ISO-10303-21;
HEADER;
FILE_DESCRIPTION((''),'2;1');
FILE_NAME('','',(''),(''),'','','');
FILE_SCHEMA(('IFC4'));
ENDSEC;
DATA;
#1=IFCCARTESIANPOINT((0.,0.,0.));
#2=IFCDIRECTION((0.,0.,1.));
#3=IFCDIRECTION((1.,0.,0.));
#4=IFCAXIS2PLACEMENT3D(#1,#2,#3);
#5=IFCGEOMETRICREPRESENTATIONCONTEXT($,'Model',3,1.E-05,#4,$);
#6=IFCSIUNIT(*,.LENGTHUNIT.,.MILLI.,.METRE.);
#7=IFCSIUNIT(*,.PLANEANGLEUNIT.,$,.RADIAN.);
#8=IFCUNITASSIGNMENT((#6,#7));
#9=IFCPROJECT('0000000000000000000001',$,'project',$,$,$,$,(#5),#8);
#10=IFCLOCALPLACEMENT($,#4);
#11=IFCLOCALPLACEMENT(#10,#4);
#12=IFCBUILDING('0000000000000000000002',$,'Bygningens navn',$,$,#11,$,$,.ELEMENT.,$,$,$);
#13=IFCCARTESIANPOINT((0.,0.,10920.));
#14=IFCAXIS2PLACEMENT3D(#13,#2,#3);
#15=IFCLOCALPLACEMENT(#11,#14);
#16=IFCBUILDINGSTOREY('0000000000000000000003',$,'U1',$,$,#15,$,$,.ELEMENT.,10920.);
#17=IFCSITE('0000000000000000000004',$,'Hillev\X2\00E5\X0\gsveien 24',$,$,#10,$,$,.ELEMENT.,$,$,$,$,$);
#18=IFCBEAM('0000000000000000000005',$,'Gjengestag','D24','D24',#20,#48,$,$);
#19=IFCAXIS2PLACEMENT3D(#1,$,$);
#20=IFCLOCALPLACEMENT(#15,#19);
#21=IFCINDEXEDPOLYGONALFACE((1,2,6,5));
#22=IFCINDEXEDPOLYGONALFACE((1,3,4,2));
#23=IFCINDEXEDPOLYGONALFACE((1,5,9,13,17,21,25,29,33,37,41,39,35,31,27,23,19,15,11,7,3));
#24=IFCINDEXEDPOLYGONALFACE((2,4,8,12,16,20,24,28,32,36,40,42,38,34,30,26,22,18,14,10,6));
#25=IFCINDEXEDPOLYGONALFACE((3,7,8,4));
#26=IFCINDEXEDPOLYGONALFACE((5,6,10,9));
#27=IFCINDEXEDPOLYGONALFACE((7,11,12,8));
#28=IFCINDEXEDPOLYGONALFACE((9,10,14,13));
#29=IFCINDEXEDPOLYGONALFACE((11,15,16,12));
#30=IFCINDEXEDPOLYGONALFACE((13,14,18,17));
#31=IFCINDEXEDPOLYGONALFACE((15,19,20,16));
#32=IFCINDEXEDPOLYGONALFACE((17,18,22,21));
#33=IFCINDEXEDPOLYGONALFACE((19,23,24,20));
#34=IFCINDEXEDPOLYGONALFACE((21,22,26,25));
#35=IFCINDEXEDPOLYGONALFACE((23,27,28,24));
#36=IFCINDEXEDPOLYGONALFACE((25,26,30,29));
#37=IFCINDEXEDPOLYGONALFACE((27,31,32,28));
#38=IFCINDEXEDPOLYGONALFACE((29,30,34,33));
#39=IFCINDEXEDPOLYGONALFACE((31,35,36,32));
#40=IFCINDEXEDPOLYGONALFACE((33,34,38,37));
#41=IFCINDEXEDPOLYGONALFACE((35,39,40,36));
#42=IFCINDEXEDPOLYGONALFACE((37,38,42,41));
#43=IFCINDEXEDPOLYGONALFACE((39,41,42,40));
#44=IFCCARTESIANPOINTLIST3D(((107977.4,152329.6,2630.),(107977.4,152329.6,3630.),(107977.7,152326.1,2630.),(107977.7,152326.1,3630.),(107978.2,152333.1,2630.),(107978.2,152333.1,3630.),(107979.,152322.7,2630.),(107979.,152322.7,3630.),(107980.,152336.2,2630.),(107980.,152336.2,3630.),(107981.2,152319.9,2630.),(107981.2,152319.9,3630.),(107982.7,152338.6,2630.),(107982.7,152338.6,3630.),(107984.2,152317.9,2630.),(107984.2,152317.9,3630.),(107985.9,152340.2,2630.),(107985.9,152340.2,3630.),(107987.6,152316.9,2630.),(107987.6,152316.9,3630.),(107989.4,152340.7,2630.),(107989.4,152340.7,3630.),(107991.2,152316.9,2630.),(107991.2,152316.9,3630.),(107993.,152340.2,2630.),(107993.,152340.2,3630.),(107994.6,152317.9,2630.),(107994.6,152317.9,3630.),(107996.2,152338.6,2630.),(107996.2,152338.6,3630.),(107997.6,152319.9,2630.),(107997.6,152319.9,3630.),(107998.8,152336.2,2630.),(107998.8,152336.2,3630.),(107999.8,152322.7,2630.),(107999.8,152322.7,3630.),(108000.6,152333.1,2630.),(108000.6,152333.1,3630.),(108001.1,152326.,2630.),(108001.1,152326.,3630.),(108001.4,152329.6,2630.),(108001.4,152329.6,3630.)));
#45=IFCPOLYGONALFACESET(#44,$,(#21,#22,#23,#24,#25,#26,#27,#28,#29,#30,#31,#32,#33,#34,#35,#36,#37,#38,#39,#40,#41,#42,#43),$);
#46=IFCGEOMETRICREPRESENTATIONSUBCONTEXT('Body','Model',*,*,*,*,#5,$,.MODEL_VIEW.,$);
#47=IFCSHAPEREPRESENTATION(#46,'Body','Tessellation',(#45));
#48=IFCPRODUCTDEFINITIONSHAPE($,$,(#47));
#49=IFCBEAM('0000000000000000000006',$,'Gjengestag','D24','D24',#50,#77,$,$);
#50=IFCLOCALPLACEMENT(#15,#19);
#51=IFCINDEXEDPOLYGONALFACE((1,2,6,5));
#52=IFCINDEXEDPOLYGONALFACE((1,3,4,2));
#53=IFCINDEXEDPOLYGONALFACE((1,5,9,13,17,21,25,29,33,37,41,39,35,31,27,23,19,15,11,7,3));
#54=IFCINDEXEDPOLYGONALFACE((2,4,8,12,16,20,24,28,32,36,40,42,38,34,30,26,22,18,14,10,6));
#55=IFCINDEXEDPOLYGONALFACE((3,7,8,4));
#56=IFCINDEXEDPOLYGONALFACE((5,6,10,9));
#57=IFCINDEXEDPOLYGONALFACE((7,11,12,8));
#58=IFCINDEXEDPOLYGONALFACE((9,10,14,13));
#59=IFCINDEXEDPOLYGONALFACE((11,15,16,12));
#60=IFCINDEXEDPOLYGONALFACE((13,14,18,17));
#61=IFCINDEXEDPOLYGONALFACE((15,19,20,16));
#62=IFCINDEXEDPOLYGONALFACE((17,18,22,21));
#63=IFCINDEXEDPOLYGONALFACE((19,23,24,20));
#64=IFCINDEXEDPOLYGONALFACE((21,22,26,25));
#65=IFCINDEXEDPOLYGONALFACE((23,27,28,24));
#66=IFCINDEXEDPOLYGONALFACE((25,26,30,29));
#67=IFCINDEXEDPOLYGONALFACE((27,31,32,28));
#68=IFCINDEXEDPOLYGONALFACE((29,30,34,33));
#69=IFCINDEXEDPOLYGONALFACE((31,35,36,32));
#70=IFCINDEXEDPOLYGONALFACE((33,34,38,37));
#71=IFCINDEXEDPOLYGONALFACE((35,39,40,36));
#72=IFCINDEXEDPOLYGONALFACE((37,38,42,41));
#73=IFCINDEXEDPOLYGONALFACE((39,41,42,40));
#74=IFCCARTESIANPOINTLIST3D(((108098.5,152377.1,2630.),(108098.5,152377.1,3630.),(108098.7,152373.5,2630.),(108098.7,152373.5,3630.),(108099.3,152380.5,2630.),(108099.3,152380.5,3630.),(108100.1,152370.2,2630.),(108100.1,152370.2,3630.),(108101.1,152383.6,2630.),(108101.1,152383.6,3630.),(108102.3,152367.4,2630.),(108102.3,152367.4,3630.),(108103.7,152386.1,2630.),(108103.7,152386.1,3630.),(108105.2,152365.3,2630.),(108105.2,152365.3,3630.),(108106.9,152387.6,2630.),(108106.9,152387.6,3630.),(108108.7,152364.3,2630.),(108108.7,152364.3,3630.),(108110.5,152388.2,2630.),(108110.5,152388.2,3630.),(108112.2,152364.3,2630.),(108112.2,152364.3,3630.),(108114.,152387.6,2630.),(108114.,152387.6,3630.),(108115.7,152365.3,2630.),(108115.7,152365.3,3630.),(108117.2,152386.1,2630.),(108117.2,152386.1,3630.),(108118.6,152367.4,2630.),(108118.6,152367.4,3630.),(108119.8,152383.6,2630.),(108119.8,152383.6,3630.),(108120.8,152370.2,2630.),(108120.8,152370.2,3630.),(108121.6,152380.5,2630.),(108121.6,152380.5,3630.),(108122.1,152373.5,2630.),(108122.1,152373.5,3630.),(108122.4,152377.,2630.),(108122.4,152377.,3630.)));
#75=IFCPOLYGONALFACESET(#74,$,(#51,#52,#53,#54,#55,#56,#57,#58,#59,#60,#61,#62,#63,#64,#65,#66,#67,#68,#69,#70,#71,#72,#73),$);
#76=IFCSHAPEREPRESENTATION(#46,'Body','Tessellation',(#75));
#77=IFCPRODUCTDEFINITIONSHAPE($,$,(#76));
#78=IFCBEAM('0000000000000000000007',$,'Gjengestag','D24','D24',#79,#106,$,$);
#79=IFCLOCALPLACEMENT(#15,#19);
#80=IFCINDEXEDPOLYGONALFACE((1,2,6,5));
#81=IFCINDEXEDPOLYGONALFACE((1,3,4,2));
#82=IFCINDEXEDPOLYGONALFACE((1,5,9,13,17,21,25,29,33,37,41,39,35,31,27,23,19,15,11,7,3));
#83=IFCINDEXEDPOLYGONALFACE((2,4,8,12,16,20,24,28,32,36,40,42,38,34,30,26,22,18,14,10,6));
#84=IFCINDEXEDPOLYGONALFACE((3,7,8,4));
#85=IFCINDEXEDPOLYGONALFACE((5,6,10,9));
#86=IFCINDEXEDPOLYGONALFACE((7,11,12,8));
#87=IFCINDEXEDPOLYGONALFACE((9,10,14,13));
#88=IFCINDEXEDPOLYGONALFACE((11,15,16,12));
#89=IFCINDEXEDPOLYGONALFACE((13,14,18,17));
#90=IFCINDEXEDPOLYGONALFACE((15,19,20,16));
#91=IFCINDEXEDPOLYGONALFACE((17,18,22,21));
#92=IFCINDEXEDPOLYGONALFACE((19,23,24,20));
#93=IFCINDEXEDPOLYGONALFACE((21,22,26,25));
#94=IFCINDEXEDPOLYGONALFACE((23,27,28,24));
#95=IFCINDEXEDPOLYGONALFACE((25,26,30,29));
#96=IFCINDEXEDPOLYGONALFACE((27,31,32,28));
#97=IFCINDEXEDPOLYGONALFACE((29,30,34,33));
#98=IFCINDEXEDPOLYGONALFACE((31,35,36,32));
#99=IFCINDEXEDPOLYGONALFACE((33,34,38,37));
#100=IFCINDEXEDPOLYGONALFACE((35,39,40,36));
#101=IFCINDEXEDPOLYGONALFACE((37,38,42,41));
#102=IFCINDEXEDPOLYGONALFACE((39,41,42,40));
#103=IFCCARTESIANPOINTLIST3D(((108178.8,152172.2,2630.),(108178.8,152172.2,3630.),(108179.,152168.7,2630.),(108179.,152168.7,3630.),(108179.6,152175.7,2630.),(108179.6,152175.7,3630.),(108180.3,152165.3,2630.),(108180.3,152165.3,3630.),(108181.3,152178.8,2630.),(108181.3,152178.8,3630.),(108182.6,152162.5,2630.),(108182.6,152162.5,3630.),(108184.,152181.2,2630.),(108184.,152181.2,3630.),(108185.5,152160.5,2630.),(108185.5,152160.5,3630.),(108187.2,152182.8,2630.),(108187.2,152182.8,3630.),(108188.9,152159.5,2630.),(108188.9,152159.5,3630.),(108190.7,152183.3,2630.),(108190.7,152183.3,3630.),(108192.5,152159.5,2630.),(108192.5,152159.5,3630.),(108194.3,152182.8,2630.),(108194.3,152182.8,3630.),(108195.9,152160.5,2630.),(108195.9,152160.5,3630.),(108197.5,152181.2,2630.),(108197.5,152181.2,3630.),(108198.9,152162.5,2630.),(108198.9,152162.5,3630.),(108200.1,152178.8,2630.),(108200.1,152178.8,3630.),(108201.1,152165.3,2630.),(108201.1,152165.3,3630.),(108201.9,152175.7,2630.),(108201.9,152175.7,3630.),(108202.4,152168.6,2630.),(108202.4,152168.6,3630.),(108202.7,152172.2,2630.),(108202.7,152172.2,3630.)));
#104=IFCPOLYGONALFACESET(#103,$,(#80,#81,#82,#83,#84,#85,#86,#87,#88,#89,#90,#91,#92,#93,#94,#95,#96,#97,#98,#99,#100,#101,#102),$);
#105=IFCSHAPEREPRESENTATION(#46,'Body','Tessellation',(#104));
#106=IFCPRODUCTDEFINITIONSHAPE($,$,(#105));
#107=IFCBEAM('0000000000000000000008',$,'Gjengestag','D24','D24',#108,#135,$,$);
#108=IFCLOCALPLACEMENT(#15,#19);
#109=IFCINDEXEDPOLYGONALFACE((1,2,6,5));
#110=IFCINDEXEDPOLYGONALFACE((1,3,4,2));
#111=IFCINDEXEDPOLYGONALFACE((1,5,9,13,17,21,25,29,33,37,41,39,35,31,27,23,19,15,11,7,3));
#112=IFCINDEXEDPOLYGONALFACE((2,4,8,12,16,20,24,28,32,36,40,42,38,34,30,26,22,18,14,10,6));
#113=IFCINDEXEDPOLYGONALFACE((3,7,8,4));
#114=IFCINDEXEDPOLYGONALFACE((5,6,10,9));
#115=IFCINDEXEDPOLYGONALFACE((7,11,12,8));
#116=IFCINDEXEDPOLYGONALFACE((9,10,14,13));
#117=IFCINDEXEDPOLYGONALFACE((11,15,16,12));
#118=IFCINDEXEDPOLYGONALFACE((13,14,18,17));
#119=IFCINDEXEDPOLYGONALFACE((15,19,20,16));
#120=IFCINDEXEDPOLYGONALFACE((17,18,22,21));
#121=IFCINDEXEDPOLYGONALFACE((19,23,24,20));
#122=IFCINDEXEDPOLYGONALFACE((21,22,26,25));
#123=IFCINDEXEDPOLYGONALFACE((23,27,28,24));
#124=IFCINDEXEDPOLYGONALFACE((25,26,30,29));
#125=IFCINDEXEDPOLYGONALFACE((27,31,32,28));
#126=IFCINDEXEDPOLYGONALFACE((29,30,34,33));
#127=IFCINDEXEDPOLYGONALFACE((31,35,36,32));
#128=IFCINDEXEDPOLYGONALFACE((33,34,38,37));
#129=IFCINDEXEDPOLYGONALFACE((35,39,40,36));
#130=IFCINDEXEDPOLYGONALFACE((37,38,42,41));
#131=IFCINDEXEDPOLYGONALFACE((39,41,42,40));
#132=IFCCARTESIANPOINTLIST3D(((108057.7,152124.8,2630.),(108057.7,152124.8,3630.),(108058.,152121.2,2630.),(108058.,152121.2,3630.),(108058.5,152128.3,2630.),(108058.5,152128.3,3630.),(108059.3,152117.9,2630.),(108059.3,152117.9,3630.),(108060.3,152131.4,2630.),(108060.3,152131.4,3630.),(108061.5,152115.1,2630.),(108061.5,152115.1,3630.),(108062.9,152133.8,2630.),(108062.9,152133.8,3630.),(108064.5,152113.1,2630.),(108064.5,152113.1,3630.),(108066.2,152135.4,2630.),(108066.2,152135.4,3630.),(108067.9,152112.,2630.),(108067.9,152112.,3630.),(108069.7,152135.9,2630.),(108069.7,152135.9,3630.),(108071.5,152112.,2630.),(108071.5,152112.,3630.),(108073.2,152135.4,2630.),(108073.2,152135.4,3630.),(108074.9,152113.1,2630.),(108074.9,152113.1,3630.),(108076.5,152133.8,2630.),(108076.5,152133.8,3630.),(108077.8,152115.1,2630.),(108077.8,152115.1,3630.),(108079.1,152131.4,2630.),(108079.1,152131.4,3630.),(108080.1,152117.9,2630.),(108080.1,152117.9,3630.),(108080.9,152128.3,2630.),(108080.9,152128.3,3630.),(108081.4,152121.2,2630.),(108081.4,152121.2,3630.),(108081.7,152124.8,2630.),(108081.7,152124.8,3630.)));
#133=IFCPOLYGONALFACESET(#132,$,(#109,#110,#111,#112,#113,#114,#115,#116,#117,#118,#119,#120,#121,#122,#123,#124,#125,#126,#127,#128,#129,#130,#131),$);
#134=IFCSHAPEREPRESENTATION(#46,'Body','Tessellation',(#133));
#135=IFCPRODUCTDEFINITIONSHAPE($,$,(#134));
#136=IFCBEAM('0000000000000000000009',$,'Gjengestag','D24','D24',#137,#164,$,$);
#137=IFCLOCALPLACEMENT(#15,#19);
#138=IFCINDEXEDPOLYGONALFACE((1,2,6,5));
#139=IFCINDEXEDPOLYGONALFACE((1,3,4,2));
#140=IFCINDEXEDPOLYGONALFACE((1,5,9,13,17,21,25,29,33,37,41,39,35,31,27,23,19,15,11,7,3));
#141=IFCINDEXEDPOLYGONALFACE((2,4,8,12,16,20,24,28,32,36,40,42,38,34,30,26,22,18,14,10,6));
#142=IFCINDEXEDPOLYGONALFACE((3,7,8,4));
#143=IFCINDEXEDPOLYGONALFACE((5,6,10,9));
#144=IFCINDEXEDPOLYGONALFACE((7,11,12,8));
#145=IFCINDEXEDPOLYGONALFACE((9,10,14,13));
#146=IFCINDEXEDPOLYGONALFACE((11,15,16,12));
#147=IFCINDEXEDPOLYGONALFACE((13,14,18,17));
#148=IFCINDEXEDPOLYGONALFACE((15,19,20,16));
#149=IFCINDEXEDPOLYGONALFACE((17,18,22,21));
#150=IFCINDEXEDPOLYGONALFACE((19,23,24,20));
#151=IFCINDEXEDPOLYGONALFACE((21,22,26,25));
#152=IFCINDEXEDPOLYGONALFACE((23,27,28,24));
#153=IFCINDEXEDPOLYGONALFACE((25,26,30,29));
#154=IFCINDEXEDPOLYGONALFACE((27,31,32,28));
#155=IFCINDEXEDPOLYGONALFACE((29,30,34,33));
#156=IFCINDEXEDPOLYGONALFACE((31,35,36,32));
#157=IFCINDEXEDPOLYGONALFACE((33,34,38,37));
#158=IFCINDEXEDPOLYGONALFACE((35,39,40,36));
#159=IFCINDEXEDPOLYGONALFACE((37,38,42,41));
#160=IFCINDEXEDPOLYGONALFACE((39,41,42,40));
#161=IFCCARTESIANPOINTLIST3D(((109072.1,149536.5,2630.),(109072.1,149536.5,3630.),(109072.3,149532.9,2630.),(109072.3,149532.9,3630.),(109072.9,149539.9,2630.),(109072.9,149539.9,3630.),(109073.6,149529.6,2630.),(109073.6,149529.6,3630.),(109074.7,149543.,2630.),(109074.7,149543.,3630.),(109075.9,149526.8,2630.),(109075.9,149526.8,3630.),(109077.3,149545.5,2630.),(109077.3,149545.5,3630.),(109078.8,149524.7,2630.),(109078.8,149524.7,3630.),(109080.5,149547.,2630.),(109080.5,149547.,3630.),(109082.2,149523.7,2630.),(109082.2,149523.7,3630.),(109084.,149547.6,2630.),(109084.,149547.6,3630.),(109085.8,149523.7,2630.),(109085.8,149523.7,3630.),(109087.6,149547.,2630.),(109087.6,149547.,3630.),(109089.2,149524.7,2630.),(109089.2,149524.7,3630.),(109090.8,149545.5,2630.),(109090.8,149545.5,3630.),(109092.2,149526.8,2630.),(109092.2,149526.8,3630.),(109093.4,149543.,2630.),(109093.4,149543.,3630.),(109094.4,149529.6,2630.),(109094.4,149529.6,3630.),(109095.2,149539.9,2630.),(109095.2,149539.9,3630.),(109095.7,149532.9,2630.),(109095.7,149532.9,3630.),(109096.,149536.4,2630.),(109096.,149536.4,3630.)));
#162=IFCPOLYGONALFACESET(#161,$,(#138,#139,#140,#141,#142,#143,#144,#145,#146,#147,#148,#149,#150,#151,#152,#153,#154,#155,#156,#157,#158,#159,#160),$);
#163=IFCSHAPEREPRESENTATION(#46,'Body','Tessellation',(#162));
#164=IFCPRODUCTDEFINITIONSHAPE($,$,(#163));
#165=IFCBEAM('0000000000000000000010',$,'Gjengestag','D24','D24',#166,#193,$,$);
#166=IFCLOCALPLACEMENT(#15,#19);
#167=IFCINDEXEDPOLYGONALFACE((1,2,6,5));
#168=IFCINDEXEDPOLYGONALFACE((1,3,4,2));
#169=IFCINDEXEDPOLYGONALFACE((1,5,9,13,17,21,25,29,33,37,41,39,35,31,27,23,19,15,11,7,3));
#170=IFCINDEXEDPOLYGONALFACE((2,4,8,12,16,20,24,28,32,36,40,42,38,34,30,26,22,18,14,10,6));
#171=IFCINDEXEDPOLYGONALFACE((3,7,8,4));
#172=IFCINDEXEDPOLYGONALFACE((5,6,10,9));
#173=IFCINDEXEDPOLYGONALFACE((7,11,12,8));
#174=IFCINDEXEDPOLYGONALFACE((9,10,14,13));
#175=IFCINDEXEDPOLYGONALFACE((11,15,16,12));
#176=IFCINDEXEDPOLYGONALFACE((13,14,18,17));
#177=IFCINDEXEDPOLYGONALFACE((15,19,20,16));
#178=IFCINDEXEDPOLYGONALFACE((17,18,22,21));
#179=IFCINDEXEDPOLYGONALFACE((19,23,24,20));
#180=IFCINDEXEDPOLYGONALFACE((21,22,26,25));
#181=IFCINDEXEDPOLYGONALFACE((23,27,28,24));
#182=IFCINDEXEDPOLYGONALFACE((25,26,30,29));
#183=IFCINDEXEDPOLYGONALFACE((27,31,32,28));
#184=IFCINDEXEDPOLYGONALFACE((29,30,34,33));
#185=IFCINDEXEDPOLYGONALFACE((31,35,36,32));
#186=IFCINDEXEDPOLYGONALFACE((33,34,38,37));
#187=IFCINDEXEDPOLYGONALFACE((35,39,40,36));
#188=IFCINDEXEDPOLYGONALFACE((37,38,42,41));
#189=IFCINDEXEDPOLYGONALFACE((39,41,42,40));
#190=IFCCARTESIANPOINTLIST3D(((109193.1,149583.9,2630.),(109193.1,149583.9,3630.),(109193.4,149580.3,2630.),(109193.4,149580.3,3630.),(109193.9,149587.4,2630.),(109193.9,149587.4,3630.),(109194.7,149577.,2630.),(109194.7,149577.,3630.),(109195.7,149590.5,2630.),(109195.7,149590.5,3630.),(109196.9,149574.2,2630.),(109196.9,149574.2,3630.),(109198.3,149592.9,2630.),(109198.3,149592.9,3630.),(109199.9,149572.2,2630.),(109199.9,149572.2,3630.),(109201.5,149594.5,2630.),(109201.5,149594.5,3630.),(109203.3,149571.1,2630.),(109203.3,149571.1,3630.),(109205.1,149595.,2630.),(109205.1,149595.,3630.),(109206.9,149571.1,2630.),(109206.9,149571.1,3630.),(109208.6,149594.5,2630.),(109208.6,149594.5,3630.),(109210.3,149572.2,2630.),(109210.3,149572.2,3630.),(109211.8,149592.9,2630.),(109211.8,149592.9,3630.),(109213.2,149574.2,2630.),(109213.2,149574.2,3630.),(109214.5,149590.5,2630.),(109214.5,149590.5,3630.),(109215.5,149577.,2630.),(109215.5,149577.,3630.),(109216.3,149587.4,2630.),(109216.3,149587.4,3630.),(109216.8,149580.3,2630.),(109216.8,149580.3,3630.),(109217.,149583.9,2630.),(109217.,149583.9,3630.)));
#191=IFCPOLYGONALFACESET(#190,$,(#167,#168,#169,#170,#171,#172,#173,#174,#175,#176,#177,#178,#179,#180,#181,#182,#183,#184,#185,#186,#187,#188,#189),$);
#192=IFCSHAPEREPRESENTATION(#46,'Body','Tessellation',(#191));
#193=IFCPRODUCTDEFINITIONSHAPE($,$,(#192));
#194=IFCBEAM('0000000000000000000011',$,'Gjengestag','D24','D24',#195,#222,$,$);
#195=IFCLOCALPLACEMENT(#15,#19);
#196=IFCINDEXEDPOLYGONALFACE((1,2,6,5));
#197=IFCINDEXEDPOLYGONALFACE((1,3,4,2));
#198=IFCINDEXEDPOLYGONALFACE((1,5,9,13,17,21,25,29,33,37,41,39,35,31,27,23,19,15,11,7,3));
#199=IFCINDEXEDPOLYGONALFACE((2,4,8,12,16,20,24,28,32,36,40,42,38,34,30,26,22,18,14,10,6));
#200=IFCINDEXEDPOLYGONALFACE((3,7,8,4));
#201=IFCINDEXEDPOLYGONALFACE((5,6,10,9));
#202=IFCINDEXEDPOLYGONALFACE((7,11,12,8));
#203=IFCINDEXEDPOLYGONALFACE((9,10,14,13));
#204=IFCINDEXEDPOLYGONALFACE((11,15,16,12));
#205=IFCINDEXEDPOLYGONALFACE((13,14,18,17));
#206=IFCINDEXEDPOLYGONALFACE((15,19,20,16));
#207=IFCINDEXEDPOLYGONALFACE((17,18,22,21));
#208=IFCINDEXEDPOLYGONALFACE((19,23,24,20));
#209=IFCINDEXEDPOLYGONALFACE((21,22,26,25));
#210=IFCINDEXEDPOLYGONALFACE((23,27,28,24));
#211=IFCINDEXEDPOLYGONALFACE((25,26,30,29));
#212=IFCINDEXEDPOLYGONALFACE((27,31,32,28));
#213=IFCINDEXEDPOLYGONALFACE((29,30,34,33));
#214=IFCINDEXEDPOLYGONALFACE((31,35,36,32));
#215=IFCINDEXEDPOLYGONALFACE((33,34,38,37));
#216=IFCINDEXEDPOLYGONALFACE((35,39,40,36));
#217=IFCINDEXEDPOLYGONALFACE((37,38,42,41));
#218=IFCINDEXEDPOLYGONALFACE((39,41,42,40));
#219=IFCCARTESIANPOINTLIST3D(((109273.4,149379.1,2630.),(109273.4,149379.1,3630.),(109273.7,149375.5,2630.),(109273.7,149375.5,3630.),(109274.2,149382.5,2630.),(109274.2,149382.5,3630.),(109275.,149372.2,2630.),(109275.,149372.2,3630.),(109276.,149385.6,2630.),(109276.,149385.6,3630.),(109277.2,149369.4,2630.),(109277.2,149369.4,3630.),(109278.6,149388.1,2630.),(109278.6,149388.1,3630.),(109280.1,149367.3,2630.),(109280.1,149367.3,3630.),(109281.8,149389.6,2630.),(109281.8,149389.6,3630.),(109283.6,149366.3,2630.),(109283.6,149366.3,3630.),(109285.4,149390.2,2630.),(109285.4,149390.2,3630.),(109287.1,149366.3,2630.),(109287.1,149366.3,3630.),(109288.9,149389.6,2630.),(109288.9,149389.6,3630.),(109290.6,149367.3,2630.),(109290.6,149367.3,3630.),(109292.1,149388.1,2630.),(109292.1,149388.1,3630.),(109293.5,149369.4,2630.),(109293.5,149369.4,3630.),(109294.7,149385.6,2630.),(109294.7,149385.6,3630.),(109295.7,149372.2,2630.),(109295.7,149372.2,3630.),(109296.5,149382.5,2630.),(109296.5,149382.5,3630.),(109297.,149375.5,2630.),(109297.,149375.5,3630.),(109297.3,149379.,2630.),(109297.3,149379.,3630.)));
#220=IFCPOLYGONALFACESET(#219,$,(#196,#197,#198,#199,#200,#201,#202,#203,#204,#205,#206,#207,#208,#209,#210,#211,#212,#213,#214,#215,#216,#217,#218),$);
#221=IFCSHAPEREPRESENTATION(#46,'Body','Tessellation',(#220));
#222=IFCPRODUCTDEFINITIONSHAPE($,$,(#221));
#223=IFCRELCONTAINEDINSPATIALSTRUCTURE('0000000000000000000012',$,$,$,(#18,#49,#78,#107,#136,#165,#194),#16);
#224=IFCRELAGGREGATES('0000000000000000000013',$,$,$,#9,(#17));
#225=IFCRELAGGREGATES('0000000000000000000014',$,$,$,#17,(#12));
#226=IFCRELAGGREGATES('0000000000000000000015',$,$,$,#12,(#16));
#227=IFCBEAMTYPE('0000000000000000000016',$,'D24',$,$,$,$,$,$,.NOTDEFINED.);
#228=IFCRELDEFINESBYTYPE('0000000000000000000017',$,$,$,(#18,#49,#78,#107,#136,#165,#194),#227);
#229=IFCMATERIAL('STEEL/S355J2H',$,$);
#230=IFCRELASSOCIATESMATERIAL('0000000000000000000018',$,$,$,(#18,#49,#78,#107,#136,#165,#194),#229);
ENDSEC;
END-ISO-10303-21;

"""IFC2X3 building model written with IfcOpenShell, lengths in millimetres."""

from ifc_helpers import new_model, si_unit, frame, frame_2d, origin_with_axes, place, context, subcontext, project, spatial, circle, extrude, material, type_object, element, save


model = new_model("IFC2X3")

# Units and contexts
model_context = context("Model", 3, precision=1e-05, world=origin_with_axes())
body_context = subcontext(model_context, "Body", "Model", "MODEL_VIEW")
ifc_project = project(units=[si_unit("LENGTHUNIT", "METRE", prefix="MILLI"), si_unit("PLANEANGLEUNIT", "RADIAN")], contexts=[model_context])

# Site, building, storey
site_placement = place(None, origin_with_axes())
site = spatial("IfcSite", under=ifc_project, at=site_placement, Name="Hillevågsveien 24", CompositionType="ELEMENT")
building_placement = place(site_placement, origin_with_axes())
building = spatial("IfcBuilding", under=site, at=building_placement, Name="Bygningens navn", CompositionType="ELEMENT")
storey_placement = place(building_placement, frame((0.0, 0.0, 10920.0), z_axis=(0.0, 0.0, 1.0), x_axis=(1.0, 0.0, 0.0)))
storey = spatial("IfcBuildingStorey", under=building, at=storey_placement, Name="U1", CompositionType="ELEMENT", Elevation=10920.0)

# Beams
ifc_material = material(Name="STEEL/S355J2H")
beam_type_1 = type_object("IfcBeamType", Name="D24", PredefinedType="NOTDEFINED")
for number, where, z_axis, x_axis, name in (
    (1, (107989.4, 152328.7, 3630.0), (-0.364877, 0.931056, 0.0), (0.0, 0.0, -1.0), "Gjengestag"),
    (2, (108110.4, 152376.2, 3630.0), (-0.364877, 0.931056, 0.0), (0.0, 0.0, -1.0), "Gjengestag"),
    (3, (108190.7, 152171.3, 3630.0), (-0.364877, 0.931056, 0.0), (0.0, 0.0, -1.0), "Gjengestag"),
    (4, (108069.7, 152123.9, 3630.0), (-0.364877, 0.931056, 0.0), (0.0, 0.0, -1.0), "Gjengestag"),
    (5, (109084.0, 149535.6, 3630.0), (-0.364877, 0.931056, 0.0), (0.0, 0.0, -1.0), "Gjengestag"),
    (6, (109205.1, 149583.0, 3630.0), (-0.364877, 0.931056, 0.0), (0.0, 0.0, -1.0), "Gjengestag"),
    (7, (109285.4, 149378.2, 3630.0), (-0.364877, 0.931056, 0.0), (0.0, 0.0, -1.0), "Gjengestag"),
):
    element("IfcBeam", number, at=place(storey_placement, frame(where, z_axis=z_axis, x_axis=x_axis)), inside=storey, type_object=beam_type_1, material=ifc_material, Name=name, Description="D24", ObjectType="D24", context=body_context, shape_type="SweptSolid", body=[
        extrude(circle(Radius=12.0, at=frame_2d((0.0, 0.0), x_axis=(1.0, 0.0))), frame((1000.0, 0.0, 0.0), z_axis=(-1.0, 0.0, 0.0), x_axis=(0.0, -1.0, 0.0)), (0.0, 0.0, 1.0), 1000.0),
    ])

save(model, "model.ifc")
